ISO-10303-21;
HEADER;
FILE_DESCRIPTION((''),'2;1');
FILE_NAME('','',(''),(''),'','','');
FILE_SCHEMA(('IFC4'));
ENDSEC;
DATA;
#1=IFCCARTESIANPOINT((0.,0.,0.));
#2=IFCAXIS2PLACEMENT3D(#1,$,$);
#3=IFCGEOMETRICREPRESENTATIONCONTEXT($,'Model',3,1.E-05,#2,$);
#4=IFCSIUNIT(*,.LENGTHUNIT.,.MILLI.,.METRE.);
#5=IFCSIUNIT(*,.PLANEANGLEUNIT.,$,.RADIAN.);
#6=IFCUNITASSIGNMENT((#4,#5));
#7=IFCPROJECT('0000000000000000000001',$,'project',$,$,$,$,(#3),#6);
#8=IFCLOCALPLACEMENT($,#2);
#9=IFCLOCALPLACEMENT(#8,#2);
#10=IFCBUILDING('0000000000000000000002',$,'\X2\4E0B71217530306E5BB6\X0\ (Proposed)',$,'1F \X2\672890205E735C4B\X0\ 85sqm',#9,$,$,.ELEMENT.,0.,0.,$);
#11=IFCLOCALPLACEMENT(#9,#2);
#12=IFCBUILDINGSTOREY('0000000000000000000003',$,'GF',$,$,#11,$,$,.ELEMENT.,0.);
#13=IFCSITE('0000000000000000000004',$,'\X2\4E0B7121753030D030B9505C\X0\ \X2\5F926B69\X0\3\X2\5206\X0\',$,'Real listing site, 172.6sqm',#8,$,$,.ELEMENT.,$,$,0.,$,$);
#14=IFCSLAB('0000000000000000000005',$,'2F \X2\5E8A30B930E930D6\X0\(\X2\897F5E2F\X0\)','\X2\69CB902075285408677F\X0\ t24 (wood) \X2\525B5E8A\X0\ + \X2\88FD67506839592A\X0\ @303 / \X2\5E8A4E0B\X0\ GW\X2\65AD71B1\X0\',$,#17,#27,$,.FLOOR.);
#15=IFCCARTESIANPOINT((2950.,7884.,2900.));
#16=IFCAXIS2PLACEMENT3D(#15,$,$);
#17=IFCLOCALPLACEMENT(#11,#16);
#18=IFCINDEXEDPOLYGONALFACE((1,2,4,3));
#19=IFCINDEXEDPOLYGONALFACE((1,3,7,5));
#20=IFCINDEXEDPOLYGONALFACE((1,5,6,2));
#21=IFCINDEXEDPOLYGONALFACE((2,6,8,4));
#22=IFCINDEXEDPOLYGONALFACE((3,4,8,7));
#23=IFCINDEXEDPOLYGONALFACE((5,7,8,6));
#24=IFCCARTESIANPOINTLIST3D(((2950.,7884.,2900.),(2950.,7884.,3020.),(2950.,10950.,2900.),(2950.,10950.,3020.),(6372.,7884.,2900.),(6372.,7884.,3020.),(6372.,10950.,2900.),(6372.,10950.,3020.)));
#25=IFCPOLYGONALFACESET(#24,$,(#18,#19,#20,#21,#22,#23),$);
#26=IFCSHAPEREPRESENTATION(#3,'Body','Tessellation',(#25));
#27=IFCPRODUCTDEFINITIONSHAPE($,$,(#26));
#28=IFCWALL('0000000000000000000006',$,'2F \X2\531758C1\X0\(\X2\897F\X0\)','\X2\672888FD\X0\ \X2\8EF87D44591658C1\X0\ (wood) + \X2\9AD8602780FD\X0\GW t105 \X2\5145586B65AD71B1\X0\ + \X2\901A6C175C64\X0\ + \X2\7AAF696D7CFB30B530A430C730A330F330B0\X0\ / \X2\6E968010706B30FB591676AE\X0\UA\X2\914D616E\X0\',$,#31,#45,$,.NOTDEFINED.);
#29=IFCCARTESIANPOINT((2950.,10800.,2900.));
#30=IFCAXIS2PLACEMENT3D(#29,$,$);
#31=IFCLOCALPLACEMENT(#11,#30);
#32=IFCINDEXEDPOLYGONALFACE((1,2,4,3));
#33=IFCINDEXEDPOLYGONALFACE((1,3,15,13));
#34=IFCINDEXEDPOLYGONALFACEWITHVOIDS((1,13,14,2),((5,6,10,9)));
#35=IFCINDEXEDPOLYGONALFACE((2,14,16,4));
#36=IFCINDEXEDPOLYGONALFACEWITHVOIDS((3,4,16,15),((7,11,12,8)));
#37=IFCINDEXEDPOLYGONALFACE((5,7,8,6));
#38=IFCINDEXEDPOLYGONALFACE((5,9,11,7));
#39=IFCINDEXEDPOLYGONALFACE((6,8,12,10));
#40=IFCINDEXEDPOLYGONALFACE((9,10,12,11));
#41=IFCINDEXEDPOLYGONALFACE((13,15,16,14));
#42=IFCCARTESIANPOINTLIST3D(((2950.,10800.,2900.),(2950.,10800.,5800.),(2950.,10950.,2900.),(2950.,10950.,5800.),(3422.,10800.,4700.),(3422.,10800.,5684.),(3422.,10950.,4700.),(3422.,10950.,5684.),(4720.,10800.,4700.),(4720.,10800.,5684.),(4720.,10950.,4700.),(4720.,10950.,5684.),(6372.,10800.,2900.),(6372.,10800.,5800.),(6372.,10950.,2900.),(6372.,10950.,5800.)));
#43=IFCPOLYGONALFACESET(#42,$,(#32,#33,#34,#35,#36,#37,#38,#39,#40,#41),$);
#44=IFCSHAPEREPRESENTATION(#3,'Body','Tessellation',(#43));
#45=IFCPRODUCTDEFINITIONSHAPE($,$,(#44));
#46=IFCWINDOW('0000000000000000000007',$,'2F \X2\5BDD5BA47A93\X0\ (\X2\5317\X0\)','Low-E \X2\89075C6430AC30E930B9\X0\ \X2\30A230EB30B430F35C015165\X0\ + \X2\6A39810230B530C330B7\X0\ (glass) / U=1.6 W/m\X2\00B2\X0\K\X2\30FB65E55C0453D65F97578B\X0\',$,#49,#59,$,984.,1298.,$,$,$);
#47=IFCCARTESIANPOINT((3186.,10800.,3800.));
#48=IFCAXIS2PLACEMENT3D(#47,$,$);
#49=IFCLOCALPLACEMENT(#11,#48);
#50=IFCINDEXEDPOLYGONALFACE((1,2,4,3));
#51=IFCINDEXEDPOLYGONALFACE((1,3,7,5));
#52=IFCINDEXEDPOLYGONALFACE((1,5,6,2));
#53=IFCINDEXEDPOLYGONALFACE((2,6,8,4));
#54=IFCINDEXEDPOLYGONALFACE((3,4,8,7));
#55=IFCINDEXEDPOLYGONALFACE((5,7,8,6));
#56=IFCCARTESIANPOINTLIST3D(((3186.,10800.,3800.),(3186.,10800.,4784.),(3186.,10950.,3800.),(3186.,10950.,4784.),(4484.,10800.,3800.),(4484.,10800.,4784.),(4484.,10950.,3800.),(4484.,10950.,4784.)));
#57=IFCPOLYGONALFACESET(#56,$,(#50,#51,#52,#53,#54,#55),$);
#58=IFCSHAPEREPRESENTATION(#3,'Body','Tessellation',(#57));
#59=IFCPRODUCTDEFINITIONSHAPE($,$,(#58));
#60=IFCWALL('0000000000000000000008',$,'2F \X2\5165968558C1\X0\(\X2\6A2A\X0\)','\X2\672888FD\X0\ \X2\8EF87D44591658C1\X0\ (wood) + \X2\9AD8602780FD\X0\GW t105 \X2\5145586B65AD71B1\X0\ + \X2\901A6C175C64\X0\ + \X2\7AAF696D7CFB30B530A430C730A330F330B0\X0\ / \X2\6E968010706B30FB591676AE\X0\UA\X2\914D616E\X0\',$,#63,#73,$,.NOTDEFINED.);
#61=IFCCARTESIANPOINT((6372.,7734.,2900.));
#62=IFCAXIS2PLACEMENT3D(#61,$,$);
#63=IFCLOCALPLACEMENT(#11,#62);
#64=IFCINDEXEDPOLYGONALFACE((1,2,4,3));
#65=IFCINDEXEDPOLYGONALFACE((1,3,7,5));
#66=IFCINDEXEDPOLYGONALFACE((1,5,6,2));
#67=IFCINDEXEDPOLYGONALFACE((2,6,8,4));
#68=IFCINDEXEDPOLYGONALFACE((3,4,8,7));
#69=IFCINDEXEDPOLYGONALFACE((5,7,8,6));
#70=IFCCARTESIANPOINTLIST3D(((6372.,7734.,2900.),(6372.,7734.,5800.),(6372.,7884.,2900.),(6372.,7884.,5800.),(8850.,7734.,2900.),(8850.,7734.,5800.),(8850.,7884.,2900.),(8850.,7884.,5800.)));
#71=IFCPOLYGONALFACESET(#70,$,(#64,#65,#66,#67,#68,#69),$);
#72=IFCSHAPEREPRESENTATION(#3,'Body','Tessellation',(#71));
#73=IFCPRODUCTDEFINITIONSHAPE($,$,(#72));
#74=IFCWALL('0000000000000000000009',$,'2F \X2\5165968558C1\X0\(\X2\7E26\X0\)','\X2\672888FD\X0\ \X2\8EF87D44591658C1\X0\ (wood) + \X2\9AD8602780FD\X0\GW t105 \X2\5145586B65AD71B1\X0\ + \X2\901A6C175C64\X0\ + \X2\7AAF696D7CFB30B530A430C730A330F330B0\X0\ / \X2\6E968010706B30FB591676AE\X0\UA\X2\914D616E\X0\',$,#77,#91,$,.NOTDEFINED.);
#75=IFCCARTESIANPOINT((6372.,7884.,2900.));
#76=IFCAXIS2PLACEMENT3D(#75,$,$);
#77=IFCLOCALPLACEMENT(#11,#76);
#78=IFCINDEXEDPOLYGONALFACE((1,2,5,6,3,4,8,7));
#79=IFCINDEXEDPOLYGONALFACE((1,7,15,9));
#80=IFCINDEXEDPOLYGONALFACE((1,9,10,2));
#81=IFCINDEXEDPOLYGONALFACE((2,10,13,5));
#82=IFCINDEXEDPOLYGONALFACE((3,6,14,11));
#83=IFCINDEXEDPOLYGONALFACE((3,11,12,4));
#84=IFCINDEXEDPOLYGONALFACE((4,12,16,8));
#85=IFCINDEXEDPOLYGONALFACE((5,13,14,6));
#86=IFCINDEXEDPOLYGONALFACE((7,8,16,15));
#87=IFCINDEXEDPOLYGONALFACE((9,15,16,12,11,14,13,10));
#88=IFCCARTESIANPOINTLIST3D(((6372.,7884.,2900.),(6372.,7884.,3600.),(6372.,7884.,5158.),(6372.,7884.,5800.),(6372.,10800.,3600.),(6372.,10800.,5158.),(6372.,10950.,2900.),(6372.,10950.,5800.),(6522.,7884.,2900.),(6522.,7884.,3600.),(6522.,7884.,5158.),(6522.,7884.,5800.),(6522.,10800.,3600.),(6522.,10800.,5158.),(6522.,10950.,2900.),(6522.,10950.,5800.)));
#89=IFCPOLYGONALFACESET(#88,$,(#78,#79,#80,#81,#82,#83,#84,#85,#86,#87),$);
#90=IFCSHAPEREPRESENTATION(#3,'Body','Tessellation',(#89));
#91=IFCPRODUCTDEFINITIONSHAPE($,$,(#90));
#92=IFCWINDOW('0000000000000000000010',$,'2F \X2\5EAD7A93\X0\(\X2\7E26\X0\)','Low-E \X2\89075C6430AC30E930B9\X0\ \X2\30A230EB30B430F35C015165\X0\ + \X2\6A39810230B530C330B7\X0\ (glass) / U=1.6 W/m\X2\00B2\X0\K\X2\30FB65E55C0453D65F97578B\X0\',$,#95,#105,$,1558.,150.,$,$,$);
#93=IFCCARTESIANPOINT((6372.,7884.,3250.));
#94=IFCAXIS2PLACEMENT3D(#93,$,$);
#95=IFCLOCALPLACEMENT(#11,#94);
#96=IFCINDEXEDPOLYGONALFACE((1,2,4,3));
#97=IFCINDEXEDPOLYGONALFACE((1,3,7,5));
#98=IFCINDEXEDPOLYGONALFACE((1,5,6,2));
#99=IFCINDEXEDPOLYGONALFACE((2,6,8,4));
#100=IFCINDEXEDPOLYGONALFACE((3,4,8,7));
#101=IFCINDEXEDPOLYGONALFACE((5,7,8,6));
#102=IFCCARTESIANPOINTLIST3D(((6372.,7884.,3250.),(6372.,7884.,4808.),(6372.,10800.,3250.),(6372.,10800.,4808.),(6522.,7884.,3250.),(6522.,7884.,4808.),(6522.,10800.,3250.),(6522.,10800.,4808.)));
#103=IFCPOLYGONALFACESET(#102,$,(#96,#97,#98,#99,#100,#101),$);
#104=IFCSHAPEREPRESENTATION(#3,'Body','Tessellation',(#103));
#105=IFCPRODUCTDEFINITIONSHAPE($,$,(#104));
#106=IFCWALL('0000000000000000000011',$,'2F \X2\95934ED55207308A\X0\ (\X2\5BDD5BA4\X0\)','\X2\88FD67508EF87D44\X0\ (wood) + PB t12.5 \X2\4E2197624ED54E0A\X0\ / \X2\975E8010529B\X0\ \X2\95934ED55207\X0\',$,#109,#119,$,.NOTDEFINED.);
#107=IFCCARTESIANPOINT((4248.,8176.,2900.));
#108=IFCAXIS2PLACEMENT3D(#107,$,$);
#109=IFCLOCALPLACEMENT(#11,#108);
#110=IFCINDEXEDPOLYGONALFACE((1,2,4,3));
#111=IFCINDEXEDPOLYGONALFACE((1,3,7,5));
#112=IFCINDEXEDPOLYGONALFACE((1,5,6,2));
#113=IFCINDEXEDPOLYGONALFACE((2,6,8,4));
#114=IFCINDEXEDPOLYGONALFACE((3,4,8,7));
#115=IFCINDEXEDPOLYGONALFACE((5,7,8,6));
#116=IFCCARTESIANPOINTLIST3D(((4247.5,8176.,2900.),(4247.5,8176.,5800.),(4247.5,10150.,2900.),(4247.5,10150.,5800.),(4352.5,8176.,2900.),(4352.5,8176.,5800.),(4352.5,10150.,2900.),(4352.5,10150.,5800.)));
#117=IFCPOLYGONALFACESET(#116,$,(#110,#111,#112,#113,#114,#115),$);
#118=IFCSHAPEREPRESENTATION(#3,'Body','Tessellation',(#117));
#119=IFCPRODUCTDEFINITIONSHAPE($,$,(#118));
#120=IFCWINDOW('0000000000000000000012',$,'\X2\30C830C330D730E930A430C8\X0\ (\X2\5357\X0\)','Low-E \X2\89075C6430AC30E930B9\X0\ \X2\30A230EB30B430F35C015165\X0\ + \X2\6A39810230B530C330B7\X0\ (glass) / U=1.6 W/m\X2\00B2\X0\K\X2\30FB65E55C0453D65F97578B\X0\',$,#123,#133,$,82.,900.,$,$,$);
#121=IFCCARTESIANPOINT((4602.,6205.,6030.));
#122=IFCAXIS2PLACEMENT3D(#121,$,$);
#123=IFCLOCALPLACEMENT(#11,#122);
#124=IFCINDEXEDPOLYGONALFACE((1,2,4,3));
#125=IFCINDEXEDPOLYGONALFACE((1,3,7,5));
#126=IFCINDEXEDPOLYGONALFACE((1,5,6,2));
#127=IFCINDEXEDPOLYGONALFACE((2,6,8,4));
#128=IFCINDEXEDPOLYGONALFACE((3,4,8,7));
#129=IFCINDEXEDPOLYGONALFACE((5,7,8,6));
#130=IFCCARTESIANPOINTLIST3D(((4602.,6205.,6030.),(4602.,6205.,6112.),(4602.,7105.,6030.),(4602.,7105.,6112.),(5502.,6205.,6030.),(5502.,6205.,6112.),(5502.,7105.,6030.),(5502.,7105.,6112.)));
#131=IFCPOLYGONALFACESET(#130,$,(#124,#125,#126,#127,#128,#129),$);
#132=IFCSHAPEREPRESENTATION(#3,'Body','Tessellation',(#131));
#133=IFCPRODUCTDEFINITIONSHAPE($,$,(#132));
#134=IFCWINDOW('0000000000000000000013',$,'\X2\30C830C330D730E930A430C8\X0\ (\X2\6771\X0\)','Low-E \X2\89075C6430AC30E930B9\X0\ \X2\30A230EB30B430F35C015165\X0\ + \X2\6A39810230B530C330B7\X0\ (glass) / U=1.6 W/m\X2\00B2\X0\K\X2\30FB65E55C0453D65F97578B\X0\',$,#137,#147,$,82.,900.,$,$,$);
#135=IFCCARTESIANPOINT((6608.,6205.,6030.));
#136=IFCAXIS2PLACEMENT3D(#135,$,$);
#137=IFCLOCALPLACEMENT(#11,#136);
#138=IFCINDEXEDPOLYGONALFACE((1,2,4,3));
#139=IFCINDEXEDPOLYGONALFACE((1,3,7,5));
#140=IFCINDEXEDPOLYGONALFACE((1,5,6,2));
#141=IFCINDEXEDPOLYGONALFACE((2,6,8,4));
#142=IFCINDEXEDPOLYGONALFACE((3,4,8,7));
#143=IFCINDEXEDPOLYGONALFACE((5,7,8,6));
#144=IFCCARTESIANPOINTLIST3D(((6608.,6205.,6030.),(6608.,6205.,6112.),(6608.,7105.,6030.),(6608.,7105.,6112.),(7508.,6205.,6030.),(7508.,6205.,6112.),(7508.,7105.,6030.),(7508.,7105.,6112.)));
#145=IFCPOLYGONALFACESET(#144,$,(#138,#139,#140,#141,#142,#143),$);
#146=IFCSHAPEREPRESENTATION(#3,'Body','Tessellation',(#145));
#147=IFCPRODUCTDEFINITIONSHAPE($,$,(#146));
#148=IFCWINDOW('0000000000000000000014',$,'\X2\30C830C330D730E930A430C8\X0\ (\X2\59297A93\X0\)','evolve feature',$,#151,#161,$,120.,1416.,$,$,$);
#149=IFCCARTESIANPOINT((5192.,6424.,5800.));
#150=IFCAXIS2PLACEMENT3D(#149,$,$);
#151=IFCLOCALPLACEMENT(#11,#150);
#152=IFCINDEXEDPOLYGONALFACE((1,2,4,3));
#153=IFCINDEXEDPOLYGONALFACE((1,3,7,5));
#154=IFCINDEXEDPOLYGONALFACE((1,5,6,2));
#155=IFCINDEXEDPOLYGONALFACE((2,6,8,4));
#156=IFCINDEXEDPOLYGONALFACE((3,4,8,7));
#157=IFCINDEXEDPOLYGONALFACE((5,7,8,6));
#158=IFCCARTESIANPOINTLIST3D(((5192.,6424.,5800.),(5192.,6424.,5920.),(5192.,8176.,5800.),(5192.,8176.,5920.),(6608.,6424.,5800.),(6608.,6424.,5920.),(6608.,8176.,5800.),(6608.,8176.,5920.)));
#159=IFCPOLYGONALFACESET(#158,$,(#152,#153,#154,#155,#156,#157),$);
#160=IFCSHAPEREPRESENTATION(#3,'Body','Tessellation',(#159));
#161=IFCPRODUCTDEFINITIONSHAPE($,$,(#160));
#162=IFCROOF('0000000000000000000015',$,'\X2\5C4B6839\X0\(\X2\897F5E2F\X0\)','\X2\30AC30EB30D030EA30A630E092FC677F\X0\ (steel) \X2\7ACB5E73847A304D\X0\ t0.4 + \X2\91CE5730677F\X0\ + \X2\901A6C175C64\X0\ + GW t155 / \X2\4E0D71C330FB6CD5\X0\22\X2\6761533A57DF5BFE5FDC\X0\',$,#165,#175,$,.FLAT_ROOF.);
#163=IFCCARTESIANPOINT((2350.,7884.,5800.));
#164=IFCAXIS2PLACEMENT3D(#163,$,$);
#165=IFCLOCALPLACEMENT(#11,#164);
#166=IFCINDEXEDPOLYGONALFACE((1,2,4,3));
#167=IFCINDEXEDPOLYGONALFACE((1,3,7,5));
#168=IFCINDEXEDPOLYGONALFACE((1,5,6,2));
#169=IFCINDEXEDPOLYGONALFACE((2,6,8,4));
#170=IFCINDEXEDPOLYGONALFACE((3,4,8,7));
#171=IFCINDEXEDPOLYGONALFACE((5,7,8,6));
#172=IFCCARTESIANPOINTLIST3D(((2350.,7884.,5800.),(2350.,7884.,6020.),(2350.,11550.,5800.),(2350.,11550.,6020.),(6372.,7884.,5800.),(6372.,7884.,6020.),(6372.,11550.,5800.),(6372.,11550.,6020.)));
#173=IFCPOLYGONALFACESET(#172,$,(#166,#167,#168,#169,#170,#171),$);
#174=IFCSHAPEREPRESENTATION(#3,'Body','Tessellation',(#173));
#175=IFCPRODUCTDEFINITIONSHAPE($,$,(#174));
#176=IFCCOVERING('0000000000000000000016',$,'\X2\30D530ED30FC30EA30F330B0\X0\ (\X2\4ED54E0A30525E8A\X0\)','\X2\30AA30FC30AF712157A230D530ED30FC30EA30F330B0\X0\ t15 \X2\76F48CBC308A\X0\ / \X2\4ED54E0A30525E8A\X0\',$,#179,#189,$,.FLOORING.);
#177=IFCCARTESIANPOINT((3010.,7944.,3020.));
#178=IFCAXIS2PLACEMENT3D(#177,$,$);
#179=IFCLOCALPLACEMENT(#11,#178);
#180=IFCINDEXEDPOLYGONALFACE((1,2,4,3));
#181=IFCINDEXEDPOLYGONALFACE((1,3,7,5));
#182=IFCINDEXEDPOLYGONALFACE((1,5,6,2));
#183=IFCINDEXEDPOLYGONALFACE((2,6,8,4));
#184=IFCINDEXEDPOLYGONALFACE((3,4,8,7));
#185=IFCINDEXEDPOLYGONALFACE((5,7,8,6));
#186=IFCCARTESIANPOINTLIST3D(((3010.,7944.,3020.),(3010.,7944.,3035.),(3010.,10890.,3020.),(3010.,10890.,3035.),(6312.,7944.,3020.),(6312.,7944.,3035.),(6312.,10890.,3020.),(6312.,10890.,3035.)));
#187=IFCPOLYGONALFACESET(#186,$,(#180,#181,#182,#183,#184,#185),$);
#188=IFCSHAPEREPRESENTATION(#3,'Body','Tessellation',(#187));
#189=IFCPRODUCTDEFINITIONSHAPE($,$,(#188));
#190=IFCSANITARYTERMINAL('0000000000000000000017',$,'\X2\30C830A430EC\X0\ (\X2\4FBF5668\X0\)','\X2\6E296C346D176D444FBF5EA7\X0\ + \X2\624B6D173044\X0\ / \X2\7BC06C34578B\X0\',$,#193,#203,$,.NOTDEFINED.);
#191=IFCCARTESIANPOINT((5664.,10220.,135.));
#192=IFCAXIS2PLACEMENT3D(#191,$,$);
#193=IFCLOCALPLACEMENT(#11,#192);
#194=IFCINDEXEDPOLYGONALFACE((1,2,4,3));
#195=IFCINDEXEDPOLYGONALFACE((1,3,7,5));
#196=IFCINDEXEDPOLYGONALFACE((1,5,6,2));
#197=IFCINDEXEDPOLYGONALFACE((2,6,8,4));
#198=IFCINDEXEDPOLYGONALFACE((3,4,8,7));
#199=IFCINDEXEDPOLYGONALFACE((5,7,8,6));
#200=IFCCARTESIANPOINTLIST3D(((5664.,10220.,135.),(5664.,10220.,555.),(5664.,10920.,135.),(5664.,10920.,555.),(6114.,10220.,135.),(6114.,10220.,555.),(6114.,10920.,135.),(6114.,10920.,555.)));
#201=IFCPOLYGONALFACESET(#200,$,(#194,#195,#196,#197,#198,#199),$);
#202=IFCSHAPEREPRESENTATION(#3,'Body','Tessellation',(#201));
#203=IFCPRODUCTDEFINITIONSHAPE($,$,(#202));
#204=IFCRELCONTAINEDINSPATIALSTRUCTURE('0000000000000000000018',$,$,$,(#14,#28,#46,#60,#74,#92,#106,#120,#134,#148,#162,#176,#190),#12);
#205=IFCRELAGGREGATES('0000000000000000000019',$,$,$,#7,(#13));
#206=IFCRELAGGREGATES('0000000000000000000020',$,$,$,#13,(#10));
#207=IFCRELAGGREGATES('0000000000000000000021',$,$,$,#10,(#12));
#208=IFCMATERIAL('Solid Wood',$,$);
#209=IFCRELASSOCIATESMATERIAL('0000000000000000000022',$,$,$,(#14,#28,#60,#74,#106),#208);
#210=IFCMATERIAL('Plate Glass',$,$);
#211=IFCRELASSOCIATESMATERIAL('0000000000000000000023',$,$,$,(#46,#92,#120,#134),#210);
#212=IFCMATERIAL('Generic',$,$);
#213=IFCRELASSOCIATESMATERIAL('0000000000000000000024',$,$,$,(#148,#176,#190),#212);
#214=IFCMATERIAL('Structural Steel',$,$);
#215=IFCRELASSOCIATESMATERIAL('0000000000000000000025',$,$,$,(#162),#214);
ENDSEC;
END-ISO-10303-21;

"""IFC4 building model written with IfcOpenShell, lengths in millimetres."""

from ifc_helpers import new_model, si_unit, frame, frame_2d, origin, place, context, project, spatial, rectangle, extrude, material, element, fill, save


model = new_model("IFC4")

# Units and contexts
model_context = context("Model", 3, precision=1e-05, world=origin())
ifc_project = project(units=[si_unit("LENGTHUNIT", "METRE", prefix="MILLI"), si_unit("PLANEANGLEUNIT", "RADIAN")], contexts=[model_context])

# Site, building, storey
site_placement = place(None, origin())
site = spatial("IfcSite", under=ifc_project, at=site_placement, Name="下無田バス停 徒歩3分", ObjectType="Real listing site, 172.6sqm", CompositionType="ELEMENT", RefElevation=0.0)
building_placement = place(site_placement, origin())
building = spatial("IfcBuilding", under=site, at=building_placement, Name="下無田の家 (Proposed)", ObjectType="1F 木造平屋 85sqm", CompositionType="ELEMENT", ElevationOfRefHeight=0.0, ElevationOfTerrain=0.0)
storey_placement = place(building_placement, origin())
storey = spatial("IfcBuildingStorey", under=building, at=storey_placement, Name="GF", CompositionType="ELEMENT", Elevation=0.0)

# Slab
ifc_material_1 = material(Name="Solid Wood")
slab_placement = place(storey_placement, frame((2950.0, 7884.0, 2900.0)))
element("IfcSlab", 1, at=slab_placement, inside=storey, material=ifc_material_1, Name="2F 床スラブ(西帯)", Description="構造用合板 t24 (wood) 剛床 + 製材根太 @303 / 床下 GW断熱", PredefinedType="FLOOR", context=model_context, shape_type="SweptSolid", body=[
    extrude(rectangle(XDim=3422.0, YDim=3066.0, at=frame_2d((1711.0, 1533.0))), frame((2950.0, 7884.0, 2900.0)), (0.0, 0.0, 1.0), 120.0),
])

# Wall, opening, window
wall_1_placement = place(storey_placement, frame((2950.0, 10800.0, 2900.0)))
wall_1 = element("IfcWall", 2, at=wall_1_placement, inside=storey, material=ifc_material_1, Name="2F 北壁(西)", Description="木製 軸組外壁 (wood) + 高性能GW t105 充填断熱 + 通気層 + 窯業系サイディング / 準耐火・外皮UA配慮", PredefinedType="NOTDEFINED", context=model_context, shape_type="SweptSolid", body=[
    extrude(rectangle(XDim=3422.0, YDim=150.0, at=frame_2d((1711.0, 75.0))), frame((2950.0, 10800.0, 2900.0)), (0.0, 0.0, 1.0), 2900.0),
])
opening_1_placement = place(storey_placement, frame((3186.0, 10800.0, 3800.0)))
opening_1 = element("IfcOpeningElement", 3, at=opening_1_placement, cuts=wall_1, PredefinedType="NOTDEFINED", context=model_context, shape_type="SweptSolid", body=[
    extrude(rectangle(XDim=1298.0, YDim=150.0, at=frame_2d((649.0, 75.0))), frame((3186.0, 10800.0, 3800.0)), (0.0, 0.0, 1.0), 984.0),
])
ifc_material_2 = material(Name="Plate Glass")
window_1_placement = place(storey_placement, frame((3186.0, 10800.0, 3800.0)))
window_1 = element("IfcWindow", 4, at=window_1_placement, inside=storey, material=ifc_material_2, Name="2F 寝室窓 (北)", Description="Low-E 複層ガラス アルゴン封入 + 樹脂サッシ (glass) / U=1.6 W/m²K・日射取得型", OverallHeight=984.0, OverallWidth=1298.0, context=model_context, shape_type="SweptSolid", body=[
    extrude(rectangle(XDim=1298.0, YDim=150.0, at=frame_2d((649.0, 75.0))), frame((3186.0, 10800.0, 3800.0)), (0.0, 0.0, 1.0), 984.0),
])
fill(opening_1, window_1)

# Wall
wall_2_placement = place(storey_placement, frame((6372.0, 7734.0, 2900.0)))
element("IfcWall", 5, at=wall_2_placement, inside=storey, material=ifc_material_1, Name="2F 入隅壁(横)", Description="木製 軸組外壁 (wood) + 高性能GW t105 充填断熱 + 通気層 + 窯業系サイディング / 準耐火・外皮UA配慮", PredefinedType="NOTDEFINED", context=model_context, shape_type="SweptSolid", body=[
    extrude(rectangle(XDim=2478.0, YDim=150.0, at=frame_2d((1239.0, 75.0))), frame((6372.0, 7734.0, 2900.0)), (0.0, 0.0, 1.0), 2900.0),
])

# Wall, opening, window
wall_3_placement = place(storey_placement, frame((6372.0, 7884.0, 2900.0)))
wall_3 = element("IfcWall", 6, at=wall_3_placement, inside=storey, material=ifc_material_1, Name="2F 入隅壁(縦)", Description="木製 軸組外壁 (wood) + 高性能GW t105 充填断熱 + 通気層 + 窯業系サイディング / 準耐火・外皮UA配慮", PredefinedType="NOTDEFINED", context=model_context, shape_type="SweptSolid", body=[
    extrude(rectangle(XDim=150.0, YDim=3066.0, at=frame_2d((75.0, 1533.0))), frame((6372.0, 7884.0, 2900.0)), (0.0, 0.0, 1.0), 2900.0),
])
opening_2_placement = place(storey_placement, frame((6372.0, 7884.0, 3250.0)))
opening_2 = element("IfcOpeningElement", 7, at=opening_2_placement, cuts=wall_3, PredefinedType="NOTDEFINED", context=model_context, shape_type="SweptSolid", body=[
    extrude(rectangle(XDim=150.0, YDim=2916.0, at=frame_2d((75.0, 1458.0))), frame((6372.0, 7884.0, 3250.0)), (0.0, 0.0, 1.0), 1558.0),
])
window_2_placement = place(storey_placement, frame((6372.0, 7884.0, 3250.0)))
window_2 = element("IfcWindow", 8, at=window_2_placement, inside=storey, material=ifc_material_2, Name="2F 庭窓(縦)", Description="Low-E 複層ガラス アルゴン封入 + 樹脂サッシ (glass) / U=1.6 W/m²K・日射取得型", OverallHeight=1558.0, OverallWidth=150.0, context=model_context, shape_type="SweptSolid", body=[
    extrude(rectangle(XDim=150.0, YDim=2916.0, at=frame_2d((75.0, 1458.0))), frame((6372.0, 7884.0, 3250.0)), (0.0, 0.0, 1.0), 1558.0),
])
fill(opening_2, window_2)

# Wall
wall_4_placement = place(storey_placement, frame((4248.0, 8176.0, 2900.0)))
element("IfcWall", 9, at=wall_4_placement, inside=storey, material=ifc_material_1, Name="2F 間仕切り (寝室)", Description="製材軸組 (wood) + PB t12.5 両面仕上 / 非耐力 間仕切", PredefinedType="NOTDEFINED", context=model_context, shape_type="SweptSolid", body=[
    extrude(rectangle(XDim=105.0, YDim=1974.0, at=frame_2d((52.0, 987.0))), frame((4248.0, 8176.0, 2900.0)), (0.0, 0.0, 1.0), 2900.0),
])

# Windows
window_3_placement = place(storey_placement, frame((4602.0, 6205.0, 6030.0)))
element("IfcWindow", 10, at=window_3_placement, inside=storey, material=ifc_material_2, Name="トップライト (南)", Description="Low-E 複層ガラス アルゴン封入 + 樹脂サッシ (glass) / U=1.6 W/m²K・日射取得型", OverallHeight=82.0, OverallWidth=900.0, context=model_context, shape_type="SweptSolid", body=[
    extrude(rectangle(XDim=900.0, YDim=900.0, at=frame_2d((450.0, 450.0))), frame((4602.0, 6205.0, 6030.0)), (0.0, 0.0, 1.0), 82.0),
])
window_4_placement = place(storey_placement, frame((6608.0, 6205.0, 6030.0)))
element("IfcWindow", 11, at=window_4_placement, inside=storey, material=ifc_material_2, Name="トップライト (東)", Description="Low-E 複層ガラス アルゴン封入 + 樹脂サッシ (glass) / U=1.6 W/m²K・日射取得型", OverallHeight=82.0, OverallWidth=900.0, context=model_context, shape_type="SweptSolid", body=[
    extrude(rectangle(XDim=900.0, YDim=900.0, at=frame_2d((450.0, 450.0))), frame((6608.0, 6205.0, 6030.0)), (0.0, 0.0, 1.0), 82.0),
])
ifc_material_3 = material(Name="Generic")
window_5_placement = place(storey_placement, frame((5192.0, 6424.0, 5800.0)))
element("IfcWindow", 12, at=window_5_placement, inside=storey, material=ifc_material_3, Name="トップライト (天窓)", Description="evolve feature", OverallHeight=120.0, OverallWidth=1416.0, context=model_context, shape_type="SweptSolid", body=[
    extrude(rectangle(XDim=1416.0, YDim=1752.0, at=frame_2d((708.0, 876.0))), frame((5192.0, 6424.0, 5800.0)), (0.0, 0.0, 1.0), 120.0),
])

# Roof
ifc_material_4 = material(Name="Structural Steel")
for number, where, name in (
    (13, (2350.0, 7884.0, 5800.0), "屋根(西帯)"),
):
    element("IfcRoof", number, at=place(storey_placement, frame(where)), inside=storey, material=ifc_material_4, Name=name, Description="ガルバリウム鋼板 (steel) 立平葺き t0.4 + 野地板 + 通気層 + GW t155 / 不燃・法22条区域対応", PredefinedType="FLAT_ROOF", context=model_context, shape_type="SweptSolid", body=[
        extrude(rectangle(XDim=4022.0, YDim=3666.0, at=frame_2d((2011.0, 1833.0))), frame((2350.0, 7884.0, 5800.0)), (0.0, 0.0, 1.0), 220.0),
    ])

# Covering
covering_placement = place(storey_placement, frame((3010.0, 7944.0, 3020.0)))
element("IfcCovering", 14, at=covering_placement, inside=storey, material=ifc_material_3, Name="フローリング (仕上げ床)", Description="オーク無垢フローリング t15 直貼り / 仕上げ床", PredefinedType="FLOORING", context=model_context, shape_type="SweptSolid", body=[
    extrude(rectangle(XDim=3302.0, YDim=2946.0, at=frame_2d((1651.0, 1473.0))), frame((3010.0, 7944.0, 3020.0)), (0.0, 0.0, 1.0), 15.0),
])

# Sanitary terminal
sanitary_terminal_placement = place(storey_placement, frame((5664.0, 10220.0, 135.0)))
element("IfcSanitaryTerminal", 15, at=sanitary_terminal_placement, inside=storey, material=ifc_material_3, Name="トイレ (便器)", Description="温水洗浄便座 + 手洗い / 節水型", PredefinedType="NOTDEFINED", context=model_context, shape_type="SweptSolid", body=[
    extrude(rectangle(XDim=450.0, YDim=700.0, at=frame_2d((225.0, 350.0))), frame((5664.0, 10220.0, 135.0)), (0.0, 0.0, 1.0), 420.0),
])

save(model, "model.ifc")
